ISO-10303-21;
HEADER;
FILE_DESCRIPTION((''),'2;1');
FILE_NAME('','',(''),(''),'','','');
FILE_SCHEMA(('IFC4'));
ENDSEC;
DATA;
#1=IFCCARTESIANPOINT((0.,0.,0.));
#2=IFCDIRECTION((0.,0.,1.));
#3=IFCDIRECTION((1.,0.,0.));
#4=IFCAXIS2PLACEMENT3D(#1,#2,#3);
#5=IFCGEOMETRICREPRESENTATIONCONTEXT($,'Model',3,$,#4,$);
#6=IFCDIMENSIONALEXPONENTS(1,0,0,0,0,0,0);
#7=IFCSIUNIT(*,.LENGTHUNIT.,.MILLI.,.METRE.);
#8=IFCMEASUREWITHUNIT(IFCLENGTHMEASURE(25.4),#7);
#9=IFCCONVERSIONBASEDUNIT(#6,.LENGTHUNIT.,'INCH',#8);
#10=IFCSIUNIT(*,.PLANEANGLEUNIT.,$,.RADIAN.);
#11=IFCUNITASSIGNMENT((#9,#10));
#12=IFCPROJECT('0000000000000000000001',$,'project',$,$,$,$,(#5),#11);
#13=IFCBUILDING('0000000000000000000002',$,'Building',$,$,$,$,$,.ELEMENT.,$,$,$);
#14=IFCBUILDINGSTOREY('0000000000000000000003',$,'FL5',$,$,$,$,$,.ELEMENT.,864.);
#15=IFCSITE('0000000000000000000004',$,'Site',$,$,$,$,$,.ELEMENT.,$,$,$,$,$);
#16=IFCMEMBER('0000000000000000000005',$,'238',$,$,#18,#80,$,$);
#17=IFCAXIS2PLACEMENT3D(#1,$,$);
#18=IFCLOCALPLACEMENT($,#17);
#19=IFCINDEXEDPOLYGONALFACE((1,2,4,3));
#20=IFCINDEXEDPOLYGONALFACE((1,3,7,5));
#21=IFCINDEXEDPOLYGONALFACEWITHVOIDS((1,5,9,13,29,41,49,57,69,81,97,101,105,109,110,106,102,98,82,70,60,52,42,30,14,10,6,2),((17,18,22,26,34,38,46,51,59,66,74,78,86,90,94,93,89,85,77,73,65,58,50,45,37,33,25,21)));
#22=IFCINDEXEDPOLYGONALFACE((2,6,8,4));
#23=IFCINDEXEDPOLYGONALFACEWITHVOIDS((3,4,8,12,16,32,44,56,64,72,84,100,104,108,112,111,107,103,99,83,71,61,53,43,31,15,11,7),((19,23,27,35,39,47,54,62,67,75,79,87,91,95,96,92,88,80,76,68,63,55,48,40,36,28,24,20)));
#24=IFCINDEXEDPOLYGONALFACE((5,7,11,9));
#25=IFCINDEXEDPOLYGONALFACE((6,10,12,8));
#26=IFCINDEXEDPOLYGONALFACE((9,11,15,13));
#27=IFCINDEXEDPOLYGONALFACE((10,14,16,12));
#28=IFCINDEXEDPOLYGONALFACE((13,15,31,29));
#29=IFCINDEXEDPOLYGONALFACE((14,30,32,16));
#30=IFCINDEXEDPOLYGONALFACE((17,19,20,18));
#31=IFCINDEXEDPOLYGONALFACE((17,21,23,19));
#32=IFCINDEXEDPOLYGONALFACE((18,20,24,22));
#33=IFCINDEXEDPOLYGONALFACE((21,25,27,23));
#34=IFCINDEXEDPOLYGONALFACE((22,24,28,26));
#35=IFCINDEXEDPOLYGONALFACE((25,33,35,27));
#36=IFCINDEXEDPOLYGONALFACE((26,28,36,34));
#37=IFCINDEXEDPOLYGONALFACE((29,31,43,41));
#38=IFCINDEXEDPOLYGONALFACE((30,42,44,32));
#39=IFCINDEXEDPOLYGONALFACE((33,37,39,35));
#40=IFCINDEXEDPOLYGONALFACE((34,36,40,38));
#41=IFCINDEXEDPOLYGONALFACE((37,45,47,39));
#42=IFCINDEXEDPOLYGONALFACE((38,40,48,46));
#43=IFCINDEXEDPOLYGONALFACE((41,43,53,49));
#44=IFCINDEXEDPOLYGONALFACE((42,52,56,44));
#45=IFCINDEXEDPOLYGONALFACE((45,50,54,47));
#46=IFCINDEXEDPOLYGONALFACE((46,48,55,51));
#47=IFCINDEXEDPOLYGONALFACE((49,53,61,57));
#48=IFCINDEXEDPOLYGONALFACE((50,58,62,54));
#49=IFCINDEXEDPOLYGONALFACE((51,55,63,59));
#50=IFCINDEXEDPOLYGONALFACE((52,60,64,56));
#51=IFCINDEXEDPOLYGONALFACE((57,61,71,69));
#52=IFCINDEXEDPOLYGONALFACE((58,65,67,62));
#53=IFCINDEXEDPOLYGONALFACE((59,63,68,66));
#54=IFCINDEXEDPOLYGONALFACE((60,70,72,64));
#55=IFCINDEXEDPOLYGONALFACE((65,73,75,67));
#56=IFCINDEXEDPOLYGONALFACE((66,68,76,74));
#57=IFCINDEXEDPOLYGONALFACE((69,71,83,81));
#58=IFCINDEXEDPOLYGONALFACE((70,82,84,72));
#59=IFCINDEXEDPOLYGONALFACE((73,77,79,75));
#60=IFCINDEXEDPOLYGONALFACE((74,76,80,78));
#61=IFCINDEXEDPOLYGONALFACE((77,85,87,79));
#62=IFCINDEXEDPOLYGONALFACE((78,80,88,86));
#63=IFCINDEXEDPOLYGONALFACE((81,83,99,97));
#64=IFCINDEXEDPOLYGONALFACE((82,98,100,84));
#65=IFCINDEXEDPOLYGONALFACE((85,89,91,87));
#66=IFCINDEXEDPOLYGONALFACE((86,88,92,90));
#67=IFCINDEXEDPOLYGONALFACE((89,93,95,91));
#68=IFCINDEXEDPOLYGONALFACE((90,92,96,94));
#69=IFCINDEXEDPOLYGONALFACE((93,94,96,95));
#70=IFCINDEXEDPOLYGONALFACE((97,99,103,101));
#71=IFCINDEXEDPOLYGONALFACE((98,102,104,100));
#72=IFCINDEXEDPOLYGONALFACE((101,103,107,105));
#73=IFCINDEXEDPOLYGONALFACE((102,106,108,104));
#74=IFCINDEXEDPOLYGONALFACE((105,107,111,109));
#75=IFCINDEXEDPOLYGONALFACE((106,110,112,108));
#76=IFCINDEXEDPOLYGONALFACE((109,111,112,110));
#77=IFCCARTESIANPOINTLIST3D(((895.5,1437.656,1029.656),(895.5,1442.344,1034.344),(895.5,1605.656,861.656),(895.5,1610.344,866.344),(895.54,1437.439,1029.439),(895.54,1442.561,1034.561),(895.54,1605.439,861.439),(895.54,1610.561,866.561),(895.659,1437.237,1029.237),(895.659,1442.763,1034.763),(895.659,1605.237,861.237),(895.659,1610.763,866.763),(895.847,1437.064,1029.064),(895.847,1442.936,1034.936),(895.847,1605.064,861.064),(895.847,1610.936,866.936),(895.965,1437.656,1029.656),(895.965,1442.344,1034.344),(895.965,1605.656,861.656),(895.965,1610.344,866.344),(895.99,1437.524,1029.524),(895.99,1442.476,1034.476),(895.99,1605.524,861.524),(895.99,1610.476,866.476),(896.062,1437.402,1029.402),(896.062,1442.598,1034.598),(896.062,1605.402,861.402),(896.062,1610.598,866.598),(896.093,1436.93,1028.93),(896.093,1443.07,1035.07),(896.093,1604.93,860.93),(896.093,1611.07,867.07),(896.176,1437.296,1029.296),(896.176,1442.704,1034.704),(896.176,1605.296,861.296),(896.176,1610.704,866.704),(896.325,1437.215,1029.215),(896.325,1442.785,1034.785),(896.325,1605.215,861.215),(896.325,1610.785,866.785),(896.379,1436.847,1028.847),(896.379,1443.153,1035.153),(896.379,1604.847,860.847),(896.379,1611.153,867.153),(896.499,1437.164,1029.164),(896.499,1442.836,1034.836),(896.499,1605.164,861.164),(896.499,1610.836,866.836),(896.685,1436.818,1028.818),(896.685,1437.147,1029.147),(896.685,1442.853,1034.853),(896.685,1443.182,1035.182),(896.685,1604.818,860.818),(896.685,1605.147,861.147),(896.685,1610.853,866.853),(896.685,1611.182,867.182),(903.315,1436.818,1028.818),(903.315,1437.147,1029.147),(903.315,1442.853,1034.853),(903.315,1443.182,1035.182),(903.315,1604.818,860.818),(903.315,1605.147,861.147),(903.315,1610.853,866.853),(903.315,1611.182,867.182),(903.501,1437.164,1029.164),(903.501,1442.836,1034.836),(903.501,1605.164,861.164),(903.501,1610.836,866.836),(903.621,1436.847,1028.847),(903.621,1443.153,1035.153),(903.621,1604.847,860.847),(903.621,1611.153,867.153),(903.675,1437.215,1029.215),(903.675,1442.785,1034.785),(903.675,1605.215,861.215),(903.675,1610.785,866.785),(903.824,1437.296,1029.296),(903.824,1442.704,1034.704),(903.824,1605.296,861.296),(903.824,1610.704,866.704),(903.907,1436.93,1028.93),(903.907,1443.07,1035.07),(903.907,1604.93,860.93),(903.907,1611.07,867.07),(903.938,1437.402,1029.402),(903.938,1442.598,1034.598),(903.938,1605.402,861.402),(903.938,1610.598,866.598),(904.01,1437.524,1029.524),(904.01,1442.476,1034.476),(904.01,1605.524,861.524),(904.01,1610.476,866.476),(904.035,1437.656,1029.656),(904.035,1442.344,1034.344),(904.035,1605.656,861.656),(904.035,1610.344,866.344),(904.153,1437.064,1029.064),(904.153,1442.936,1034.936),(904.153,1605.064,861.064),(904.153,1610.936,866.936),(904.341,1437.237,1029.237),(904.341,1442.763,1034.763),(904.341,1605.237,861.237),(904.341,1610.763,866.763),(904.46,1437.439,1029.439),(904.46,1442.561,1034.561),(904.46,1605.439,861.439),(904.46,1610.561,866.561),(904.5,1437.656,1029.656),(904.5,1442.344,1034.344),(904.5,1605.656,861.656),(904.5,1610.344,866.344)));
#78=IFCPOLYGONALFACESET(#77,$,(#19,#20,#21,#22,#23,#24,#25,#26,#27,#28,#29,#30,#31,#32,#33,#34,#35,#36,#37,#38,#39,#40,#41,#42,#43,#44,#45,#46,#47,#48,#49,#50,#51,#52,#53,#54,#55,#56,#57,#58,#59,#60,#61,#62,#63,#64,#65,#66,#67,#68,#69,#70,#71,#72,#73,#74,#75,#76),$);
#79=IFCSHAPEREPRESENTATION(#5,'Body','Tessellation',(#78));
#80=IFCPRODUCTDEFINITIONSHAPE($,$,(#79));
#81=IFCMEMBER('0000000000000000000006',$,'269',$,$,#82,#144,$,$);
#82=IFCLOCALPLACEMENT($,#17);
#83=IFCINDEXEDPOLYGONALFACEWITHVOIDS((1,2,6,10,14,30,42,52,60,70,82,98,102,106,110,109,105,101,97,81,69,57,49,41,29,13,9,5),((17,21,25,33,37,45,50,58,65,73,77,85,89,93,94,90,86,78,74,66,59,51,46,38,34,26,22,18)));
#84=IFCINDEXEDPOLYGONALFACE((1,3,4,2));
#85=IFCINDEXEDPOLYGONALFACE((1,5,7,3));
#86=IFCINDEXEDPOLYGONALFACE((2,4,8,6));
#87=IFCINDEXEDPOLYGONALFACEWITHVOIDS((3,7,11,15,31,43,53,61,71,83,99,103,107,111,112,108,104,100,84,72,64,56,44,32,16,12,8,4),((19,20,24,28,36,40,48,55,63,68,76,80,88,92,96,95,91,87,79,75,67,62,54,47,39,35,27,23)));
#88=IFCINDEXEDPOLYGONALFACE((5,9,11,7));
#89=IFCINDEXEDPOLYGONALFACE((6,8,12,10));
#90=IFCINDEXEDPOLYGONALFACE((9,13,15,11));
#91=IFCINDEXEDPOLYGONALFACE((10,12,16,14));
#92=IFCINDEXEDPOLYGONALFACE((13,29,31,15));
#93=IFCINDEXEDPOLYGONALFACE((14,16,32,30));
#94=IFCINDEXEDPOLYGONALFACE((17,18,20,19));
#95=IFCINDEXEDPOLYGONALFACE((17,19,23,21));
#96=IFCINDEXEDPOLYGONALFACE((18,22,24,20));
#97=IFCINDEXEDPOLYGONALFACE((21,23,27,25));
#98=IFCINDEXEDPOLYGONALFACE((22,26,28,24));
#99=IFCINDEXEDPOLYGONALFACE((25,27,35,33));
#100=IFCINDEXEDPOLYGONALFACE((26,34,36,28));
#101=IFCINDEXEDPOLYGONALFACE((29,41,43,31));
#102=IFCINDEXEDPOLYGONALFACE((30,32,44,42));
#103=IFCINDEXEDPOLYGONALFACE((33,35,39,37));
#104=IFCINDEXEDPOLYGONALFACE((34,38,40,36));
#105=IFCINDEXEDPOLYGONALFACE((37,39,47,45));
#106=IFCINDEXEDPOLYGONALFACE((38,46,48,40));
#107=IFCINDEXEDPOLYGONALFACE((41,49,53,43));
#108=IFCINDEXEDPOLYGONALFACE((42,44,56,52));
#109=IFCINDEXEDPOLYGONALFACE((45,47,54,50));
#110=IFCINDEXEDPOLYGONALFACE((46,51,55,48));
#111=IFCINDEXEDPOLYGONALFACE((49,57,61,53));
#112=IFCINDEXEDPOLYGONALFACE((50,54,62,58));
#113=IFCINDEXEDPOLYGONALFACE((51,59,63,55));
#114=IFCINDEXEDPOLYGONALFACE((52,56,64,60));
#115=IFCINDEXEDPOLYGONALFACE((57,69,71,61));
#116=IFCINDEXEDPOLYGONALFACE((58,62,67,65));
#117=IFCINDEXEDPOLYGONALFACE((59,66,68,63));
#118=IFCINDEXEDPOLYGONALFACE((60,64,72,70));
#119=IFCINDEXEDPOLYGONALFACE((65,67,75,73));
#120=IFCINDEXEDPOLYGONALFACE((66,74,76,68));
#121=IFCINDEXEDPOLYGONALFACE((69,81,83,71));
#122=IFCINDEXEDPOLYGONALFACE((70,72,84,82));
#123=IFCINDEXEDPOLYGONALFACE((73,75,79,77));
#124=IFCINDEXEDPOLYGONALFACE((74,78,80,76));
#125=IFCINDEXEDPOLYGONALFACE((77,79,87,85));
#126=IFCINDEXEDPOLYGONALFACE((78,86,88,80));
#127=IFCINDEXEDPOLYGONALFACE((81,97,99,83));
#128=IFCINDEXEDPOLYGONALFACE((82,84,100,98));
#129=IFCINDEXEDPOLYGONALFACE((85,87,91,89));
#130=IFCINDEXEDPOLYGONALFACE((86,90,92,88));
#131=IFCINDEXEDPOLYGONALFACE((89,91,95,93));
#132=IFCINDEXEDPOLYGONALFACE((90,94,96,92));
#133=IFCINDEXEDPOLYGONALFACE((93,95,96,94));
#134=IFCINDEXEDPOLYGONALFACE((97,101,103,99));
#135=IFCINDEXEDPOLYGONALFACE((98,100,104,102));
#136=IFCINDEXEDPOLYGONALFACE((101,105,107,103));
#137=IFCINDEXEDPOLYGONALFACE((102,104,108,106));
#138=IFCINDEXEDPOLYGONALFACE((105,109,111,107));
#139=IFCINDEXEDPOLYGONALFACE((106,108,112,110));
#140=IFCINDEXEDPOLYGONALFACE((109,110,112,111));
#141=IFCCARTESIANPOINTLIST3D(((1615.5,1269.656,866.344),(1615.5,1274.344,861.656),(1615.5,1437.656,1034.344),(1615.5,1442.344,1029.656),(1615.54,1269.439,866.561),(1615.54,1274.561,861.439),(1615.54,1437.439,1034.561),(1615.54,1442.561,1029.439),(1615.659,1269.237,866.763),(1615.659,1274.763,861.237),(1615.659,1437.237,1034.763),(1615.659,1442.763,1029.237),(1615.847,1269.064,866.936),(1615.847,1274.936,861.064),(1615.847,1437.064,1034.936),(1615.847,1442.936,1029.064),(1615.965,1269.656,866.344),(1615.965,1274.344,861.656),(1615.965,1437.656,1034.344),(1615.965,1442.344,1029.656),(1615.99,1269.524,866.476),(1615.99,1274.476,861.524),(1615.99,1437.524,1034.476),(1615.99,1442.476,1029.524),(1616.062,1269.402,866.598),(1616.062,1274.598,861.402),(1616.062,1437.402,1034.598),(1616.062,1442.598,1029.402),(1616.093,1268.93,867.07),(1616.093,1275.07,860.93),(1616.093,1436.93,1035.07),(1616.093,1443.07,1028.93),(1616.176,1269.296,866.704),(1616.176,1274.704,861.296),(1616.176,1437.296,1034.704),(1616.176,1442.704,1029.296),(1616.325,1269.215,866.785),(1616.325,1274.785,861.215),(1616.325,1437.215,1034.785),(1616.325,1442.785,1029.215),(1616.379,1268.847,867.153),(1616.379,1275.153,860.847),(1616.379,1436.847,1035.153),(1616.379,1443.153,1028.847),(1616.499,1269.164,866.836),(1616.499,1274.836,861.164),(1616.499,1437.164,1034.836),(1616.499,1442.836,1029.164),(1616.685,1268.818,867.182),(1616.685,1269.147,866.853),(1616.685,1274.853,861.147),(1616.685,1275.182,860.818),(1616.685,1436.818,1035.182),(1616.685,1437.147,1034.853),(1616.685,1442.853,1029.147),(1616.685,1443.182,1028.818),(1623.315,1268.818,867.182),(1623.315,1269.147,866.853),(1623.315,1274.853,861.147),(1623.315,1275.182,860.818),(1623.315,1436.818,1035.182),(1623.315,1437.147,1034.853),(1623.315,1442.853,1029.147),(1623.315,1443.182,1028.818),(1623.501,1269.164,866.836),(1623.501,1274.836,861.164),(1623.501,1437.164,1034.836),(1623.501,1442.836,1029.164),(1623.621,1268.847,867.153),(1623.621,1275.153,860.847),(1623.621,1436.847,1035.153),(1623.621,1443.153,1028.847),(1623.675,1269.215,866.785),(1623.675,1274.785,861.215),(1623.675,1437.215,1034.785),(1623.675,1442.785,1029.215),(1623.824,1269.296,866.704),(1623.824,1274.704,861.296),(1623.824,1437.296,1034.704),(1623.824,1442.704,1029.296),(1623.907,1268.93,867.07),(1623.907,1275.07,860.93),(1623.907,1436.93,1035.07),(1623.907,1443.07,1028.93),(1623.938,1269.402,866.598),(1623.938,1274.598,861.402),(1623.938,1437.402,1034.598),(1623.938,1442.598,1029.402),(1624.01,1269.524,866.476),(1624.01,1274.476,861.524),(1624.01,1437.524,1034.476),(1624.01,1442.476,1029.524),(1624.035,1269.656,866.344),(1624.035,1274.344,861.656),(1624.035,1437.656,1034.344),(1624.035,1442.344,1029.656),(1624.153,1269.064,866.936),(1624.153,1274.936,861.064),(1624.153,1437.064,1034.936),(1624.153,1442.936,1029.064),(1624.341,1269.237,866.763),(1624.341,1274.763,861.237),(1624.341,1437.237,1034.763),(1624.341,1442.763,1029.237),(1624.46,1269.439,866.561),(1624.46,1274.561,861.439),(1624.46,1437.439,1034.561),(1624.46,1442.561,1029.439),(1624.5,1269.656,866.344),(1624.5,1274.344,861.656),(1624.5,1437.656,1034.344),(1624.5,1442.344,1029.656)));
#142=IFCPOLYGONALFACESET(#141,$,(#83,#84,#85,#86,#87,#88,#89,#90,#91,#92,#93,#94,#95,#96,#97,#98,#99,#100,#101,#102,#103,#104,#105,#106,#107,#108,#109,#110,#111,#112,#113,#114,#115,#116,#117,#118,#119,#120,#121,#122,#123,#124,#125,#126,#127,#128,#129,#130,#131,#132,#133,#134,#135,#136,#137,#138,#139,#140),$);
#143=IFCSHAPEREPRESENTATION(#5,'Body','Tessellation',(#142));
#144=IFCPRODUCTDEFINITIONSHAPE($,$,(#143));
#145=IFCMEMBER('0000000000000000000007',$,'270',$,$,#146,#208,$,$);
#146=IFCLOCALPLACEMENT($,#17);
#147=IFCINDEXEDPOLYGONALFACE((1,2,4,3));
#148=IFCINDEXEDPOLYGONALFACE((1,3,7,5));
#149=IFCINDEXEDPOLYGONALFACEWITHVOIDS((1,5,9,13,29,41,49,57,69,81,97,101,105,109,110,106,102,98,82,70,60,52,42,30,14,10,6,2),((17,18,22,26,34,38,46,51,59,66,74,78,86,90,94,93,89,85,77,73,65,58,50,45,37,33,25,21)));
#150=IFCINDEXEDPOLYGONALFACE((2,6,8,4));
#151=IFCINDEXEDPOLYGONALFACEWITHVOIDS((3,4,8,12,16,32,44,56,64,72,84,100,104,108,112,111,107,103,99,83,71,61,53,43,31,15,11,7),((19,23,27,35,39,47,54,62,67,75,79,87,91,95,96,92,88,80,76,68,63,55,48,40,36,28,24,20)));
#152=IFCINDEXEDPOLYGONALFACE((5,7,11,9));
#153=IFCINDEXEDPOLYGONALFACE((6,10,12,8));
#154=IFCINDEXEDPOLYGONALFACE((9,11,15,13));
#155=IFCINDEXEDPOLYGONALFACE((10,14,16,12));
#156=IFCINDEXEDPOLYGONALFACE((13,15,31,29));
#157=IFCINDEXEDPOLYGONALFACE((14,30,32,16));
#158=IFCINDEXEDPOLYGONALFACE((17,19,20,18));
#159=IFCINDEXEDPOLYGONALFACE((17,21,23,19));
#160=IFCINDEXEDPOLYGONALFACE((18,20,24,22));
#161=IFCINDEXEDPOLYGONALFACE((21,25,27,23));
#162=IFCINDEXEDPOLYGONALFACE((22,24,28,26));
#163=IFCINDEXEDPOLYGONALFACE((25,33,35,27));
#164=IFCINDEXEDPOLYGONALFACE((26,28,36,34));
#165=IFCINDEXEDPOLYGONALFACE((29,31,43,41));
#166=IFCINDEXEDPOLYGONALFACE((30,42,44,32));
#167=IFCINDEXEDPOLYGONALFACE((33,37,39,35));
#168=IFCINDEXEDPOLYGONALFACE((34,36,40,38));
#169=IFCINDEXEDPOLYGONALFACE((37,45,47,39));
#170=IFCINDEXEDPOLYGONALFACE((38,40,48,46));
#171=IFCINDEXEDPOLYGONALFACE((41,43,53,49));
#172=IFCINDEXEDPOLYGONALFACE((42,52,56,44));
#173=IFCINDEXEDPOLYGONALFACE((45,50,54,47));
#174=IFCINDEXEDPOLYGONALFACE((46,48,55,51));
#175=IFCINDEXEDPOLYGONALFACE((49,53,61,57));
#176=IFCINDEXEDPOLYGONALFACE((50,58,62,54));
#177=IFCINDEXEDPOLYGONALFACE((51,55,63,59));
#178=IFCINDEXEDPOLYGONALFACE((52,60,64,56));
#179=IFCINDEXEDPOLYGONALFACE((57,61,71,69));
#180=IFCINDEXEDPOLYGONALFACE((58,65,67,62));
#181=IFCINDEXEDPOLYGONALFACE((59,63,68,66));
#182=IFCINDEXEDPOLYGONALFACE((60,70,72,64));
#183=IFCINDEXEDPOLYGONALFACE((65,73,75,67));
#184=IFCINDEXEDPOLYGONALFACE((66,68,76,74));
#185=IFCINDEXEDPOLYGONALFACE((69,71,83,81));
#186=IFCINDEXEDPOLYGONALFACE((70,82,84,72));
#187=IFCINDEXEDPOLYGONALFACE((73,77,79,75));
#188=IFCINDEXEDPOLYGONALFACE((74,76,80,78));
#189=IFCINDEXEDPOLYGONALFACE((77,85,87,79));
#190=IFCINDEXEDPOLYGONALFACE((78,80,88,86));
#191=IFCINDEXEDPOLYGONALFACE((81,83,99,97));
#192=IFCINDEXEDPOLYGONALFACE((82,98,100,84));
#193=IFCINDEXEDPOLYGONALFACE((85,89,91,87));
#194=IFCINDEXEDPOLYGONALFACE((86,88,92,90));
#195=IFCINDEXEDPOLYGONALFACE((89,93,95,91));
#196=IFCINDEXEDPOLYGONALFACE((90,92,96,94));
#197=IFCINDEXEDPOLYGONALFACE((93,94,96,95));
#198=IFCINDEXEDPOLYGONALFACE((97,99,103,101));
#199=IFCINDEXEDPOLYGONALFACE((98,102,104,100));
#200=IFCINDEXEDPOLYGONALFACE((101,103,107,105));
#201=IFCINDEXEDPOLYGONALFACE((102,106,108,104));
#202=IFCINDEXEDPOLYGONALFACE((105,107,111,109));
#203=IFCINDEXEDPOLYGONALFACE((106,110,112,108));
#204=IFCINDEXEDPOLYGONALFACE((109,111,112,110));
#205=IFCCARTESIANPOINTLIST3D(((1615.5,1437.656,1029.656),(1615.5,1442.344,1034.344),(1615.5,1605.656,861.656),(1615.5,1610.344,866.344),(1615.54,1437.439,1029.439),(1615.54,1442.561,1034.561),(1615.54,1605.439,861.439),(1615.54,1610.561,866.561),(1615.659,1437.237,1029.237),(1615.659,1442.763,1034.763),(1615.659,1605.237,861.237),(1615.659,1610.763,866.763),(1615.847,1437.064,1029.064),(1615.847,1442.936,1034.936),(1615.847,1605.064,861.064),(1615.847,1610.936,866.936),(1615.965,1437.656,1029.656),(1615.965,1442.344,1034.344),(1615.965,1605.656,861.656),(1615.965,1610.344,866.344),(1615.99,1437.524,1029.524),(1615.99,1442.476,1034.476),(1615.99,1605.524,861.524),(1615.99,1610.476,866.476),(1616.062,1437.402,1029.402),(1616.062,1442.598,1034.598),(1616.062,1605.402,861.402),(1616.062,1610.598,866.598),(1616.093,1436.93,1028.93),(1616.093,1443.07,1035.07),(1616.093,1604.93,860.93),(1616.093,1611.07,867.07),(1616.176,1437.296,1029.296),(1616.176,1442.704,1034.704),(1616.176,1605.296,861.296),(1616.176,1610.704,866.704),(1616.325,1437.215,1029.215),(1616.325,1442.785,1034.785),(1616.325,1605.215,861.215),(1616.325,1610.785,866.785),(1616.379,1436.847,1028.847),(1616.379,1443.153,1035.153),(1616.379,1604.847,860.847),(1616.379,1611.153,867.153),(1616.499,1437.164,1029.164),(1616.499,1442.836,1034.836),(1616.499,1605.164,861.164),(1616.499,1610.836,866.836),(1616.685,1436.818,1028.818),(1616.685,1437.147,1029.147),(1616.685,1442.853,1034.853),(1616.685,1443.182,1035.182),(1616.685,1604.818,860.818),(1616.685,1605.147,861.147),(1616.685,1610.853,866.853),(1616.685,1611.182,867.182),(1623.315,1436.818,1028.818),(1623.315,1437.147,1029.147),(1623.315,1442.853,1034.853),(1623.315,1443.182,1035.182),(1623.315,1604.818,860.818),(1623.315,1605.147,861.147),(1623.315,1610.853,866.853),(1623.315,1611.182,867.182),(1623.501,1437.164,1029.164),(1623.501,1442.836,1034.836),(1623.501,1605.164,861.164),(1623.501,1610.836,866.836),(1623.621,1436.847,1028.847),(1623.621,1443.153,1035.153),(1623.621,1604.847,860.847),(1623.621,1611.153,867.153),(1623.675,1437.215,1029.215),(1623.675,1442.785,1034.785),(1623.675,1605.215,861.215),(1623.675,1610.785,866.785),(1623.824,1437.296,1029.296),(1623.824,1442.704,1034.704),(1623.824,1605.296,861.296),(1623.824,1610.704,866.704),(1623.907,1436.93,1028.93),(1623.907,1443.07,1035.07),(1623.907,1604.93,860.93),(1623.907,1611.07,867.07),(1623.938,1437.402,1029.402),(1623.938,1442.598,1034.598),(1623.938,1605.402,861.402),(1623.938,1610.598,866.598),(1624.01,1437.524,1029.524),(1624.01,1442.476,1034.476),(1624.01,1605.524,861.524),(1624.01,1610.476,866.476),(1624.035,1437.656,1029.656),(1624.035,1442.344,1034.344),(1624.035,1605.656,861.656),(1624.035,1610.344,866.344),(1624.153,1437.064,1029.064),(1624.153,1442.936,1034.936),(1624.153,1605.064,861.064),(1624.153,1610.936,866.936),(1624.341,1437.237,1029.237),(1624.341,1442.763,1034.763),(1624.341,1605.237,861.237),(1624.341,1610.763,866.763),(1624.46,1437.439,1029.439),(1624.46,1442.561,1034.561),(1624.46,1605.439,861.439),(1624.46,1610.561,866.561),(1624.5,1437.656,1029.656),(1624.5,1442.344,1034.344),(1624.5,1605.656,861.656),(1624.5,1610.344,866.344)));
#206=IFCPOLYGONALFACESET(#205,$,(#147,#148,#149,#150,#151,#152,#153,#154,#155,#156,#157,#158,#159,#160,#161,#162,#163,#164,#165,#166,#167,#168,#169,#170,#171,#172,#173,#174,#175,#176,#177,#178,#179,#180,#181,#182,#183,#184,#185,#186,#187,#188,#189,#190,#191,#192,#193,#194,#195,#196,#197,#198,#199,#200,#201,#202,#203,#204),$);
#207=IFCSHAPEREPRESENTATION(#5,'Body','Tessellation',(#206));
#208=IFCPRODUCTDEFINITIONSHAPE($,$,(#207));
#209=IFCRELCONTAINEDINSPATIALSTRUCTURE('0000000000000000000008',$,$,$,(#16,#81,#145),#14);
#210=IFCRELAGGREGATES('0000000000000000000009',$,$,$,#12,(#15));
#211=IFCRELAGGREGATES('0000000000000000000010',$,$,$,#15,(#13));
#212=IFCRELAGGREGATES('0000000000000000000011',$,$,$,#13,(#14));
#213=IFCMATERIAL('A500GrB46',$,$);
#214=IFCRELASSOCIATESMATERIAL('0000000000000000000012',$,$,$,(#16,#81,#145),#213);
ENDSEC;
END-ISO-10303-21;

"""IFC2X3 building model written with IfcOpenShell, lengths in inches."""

from ifc_helpers import new_model, entity, si_unit, converted_unit, frame, origin_with_axes, origin_2d_with_axis, place, context, project, spatial, hollow_rectangle, extrude, material, element, save


model = new_model("IFC2X3")

# Units and contexts
model_context = context("Model", 3, world=origin_with_axes())
ifc_project = project(units=[converted_unit("LENGTHUNIT", "INCH", entity("IfcLengthMeasure", 25.4), si_unit("LENGTHUNIT", "METRE", prefix="MILLI"), dimensions=[1, 0, 0, 0, 0, 0, 0]), si_unit("PLANEANGLEUNIT", "RADIAN")], contexts=[model_context])

# Site, building, storey
site = spatial("IfcSite", under=ifc_project, Name="Site", CompositionType="ELEMENT")
building = spatial("IfcBuilding", under=site, Name="Building", CompositionType="ELEMENT")
storey = spatial("IfcBuildingStorey", under=building, Name="FL5", CompositionType="ELEMENT", Elevation=864.0)

# Members
ifc_material_1 = material(Name="A500GrB46")
for number, where, z_axis, x_axis, name in (
    (1, (900.0, 1608.0, 864.0), (0.0, -0.707107, 0.707107), (1.0, 0.0, 0.0), "238"),
    (2, (1620.0, 1272.0, 864.0), (0.0, 0.707107, 0.707107), (-1.0, 0.0, 0.0), "269"),
    (3, (1620.0, 1608.0, 864.0), (0.0, -0.707107, 0.707107), (1.0, 0.0, 0.0), "270"),
):
    element("IfcMember", number, at=place(None, frame(where, z_axis=z_axis, x_axis=x_axis)), inside=storey, material=ifc_material_1, Name=name, context=model_context, shape_type="SweptSolid", body=[
        extrude(hollow_rectangle(XDim=9.0, YDim=9.0, WallThickness=0.465, InnerFilletRadius=0.72, OuterFilletRadius=1.185, at=origin_2d_with_axis()), origin_with_axes(), (0.0, 0.0, 1.0), 237.588),
    ])

save(model, "model.ifc")
